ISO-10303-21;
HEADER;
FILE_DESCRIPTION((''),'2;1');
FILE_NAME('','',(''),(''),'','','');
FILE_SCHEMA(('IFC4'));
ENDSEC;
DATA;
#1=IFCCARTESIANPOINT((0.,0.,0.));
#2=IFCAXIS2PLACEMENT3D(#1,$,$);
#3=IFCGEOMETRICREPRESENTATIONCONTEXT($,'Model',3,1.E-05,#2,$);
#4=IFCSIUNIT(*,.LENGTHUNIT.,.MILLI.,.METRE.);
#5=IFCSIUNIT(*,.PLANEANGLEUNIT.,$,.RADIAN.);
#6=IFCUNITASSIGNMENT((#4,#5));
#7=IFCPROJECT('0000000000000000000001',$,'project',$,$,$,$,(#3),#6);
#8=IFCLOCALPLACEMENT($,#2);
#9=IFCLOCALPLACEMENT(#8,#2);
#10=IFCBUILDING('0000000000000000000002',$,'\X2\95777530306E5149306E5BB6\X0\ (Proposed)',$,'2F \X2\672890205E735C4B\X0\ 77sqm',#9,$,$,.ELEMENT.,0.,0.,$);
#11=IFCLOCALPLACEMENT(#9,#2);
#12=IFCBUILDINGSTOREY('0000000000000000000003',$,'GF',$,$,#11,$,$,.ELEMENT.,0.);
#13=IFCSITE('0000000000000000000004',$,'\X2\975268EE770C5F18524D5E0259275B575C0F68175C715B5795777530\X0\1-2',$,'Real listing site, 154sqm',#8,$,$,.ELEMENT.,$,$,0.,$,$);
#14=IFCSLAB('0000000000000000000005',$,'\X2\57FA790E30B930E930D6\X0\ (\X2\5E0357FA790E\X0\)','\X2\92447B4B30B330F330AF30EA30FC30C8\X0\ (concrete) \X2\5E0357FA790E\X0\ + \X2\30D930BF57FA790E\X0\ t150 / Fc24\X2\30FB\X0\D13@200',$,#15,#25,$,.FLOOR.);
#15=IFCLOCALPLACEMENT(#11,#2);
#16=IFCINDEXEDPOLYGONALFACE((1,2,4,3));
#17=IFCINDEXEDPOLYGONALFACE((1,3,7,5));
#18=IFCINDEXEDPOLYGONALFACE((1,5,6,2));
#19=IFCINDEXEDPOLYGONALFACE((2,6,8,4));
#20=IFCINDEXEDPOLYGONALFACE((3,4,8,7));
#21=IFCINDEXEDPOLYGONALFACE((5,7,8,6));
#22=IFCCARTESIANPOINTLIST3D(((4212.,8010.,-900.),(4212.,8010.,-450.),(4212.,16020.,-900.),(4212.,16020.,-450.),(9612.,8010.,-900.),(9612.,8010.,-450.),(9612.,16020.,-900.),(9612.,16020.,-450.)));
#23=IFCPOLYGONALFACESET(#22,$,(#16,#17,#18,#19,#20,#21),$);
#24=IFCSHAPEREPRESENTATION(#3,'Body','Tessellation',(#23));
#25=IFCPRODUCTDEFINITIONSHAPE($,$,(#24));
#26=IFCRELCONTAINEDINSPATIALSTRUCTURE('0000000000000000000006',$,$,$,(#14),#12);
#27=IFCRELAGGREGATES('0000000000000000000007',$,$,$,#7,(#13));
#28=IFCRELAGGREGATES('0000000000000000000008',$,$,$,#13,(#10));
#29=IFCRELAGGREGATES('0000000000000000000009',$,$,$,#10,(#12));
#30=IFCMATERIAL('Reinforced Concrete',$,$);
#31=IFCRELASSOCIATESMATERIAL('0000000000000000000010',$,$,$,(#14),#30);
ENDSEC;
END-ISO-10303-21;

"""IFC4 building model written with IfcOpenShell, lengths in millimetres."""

from ifc_helpers import new_model, si_unit, frame, frame_2d, origin, place, context, project, spatial, rectangle, extrude, material, element, save


model = new_model("IFC4")

# Units and contexts
model_context = context("Model", 3, precision=1e-05, world=origin())
ifc_project = project(units=[si_unit("LENGTHUNIT", "METRE", prefix="MILLI"), si_unit("PLANEANGLEUNIT", "RADIAN")], contexts=[model_context])

# Site, building, storey
site_placement = place(None, origin())
site = spatial("IfcSite", under=ifc_project, at=site_placement, Name="青森県弘前市大字小栗山字長田1-2", ObjectType="Real listing site, 154sqm", CompositionType="ELEMENT", RefElevation=0.0)
building_placement = place(site_placement, origin())
building = spatial("IfcBuilding", under=site, at=building_placement, Name="長田の光の家 (Proposed)", ObjectType="2F 木造平屋 77sqm", CompositionType="ELEMENT", ElevationOfRefHeight=0.0, ElevationOfTerrain=0.0)
storey_placement = place(building_placement, origin())
storey = spatial("IfcBuildingStorey", under=building, at=storey_placement, Name="GF", CompositionType="ELEMENT", Elevation=0.0)

# Slab
ifc_material_1 = material(Name="Reinforced Concrete")
slab_1_placement = place(storey_placement, frame((2106.0, 4005.0, -450.0)))
element("IfcSlab", 1, at=slab_1_placement, inside=storey, material=ifc_material_1, Name="基礎スラブ (布基礎)", Description="鉄筋コンクリート (concrete) 布基礎 + ベタ基礎 t150 / Fc24・D13@200", PredefinedType="FLOOR", context=model_context, shape_type="SweptSolid", body=[
    extrude(rectangle(XDim=5400.0, YDim=8010.0, at=frame_2d((2700.0, 4005.0))), frame((2106.0, 4005.0, -450.0)), (0.0, 0.0, 1.0), 450.0),
])

save(model, "model.ifc")
